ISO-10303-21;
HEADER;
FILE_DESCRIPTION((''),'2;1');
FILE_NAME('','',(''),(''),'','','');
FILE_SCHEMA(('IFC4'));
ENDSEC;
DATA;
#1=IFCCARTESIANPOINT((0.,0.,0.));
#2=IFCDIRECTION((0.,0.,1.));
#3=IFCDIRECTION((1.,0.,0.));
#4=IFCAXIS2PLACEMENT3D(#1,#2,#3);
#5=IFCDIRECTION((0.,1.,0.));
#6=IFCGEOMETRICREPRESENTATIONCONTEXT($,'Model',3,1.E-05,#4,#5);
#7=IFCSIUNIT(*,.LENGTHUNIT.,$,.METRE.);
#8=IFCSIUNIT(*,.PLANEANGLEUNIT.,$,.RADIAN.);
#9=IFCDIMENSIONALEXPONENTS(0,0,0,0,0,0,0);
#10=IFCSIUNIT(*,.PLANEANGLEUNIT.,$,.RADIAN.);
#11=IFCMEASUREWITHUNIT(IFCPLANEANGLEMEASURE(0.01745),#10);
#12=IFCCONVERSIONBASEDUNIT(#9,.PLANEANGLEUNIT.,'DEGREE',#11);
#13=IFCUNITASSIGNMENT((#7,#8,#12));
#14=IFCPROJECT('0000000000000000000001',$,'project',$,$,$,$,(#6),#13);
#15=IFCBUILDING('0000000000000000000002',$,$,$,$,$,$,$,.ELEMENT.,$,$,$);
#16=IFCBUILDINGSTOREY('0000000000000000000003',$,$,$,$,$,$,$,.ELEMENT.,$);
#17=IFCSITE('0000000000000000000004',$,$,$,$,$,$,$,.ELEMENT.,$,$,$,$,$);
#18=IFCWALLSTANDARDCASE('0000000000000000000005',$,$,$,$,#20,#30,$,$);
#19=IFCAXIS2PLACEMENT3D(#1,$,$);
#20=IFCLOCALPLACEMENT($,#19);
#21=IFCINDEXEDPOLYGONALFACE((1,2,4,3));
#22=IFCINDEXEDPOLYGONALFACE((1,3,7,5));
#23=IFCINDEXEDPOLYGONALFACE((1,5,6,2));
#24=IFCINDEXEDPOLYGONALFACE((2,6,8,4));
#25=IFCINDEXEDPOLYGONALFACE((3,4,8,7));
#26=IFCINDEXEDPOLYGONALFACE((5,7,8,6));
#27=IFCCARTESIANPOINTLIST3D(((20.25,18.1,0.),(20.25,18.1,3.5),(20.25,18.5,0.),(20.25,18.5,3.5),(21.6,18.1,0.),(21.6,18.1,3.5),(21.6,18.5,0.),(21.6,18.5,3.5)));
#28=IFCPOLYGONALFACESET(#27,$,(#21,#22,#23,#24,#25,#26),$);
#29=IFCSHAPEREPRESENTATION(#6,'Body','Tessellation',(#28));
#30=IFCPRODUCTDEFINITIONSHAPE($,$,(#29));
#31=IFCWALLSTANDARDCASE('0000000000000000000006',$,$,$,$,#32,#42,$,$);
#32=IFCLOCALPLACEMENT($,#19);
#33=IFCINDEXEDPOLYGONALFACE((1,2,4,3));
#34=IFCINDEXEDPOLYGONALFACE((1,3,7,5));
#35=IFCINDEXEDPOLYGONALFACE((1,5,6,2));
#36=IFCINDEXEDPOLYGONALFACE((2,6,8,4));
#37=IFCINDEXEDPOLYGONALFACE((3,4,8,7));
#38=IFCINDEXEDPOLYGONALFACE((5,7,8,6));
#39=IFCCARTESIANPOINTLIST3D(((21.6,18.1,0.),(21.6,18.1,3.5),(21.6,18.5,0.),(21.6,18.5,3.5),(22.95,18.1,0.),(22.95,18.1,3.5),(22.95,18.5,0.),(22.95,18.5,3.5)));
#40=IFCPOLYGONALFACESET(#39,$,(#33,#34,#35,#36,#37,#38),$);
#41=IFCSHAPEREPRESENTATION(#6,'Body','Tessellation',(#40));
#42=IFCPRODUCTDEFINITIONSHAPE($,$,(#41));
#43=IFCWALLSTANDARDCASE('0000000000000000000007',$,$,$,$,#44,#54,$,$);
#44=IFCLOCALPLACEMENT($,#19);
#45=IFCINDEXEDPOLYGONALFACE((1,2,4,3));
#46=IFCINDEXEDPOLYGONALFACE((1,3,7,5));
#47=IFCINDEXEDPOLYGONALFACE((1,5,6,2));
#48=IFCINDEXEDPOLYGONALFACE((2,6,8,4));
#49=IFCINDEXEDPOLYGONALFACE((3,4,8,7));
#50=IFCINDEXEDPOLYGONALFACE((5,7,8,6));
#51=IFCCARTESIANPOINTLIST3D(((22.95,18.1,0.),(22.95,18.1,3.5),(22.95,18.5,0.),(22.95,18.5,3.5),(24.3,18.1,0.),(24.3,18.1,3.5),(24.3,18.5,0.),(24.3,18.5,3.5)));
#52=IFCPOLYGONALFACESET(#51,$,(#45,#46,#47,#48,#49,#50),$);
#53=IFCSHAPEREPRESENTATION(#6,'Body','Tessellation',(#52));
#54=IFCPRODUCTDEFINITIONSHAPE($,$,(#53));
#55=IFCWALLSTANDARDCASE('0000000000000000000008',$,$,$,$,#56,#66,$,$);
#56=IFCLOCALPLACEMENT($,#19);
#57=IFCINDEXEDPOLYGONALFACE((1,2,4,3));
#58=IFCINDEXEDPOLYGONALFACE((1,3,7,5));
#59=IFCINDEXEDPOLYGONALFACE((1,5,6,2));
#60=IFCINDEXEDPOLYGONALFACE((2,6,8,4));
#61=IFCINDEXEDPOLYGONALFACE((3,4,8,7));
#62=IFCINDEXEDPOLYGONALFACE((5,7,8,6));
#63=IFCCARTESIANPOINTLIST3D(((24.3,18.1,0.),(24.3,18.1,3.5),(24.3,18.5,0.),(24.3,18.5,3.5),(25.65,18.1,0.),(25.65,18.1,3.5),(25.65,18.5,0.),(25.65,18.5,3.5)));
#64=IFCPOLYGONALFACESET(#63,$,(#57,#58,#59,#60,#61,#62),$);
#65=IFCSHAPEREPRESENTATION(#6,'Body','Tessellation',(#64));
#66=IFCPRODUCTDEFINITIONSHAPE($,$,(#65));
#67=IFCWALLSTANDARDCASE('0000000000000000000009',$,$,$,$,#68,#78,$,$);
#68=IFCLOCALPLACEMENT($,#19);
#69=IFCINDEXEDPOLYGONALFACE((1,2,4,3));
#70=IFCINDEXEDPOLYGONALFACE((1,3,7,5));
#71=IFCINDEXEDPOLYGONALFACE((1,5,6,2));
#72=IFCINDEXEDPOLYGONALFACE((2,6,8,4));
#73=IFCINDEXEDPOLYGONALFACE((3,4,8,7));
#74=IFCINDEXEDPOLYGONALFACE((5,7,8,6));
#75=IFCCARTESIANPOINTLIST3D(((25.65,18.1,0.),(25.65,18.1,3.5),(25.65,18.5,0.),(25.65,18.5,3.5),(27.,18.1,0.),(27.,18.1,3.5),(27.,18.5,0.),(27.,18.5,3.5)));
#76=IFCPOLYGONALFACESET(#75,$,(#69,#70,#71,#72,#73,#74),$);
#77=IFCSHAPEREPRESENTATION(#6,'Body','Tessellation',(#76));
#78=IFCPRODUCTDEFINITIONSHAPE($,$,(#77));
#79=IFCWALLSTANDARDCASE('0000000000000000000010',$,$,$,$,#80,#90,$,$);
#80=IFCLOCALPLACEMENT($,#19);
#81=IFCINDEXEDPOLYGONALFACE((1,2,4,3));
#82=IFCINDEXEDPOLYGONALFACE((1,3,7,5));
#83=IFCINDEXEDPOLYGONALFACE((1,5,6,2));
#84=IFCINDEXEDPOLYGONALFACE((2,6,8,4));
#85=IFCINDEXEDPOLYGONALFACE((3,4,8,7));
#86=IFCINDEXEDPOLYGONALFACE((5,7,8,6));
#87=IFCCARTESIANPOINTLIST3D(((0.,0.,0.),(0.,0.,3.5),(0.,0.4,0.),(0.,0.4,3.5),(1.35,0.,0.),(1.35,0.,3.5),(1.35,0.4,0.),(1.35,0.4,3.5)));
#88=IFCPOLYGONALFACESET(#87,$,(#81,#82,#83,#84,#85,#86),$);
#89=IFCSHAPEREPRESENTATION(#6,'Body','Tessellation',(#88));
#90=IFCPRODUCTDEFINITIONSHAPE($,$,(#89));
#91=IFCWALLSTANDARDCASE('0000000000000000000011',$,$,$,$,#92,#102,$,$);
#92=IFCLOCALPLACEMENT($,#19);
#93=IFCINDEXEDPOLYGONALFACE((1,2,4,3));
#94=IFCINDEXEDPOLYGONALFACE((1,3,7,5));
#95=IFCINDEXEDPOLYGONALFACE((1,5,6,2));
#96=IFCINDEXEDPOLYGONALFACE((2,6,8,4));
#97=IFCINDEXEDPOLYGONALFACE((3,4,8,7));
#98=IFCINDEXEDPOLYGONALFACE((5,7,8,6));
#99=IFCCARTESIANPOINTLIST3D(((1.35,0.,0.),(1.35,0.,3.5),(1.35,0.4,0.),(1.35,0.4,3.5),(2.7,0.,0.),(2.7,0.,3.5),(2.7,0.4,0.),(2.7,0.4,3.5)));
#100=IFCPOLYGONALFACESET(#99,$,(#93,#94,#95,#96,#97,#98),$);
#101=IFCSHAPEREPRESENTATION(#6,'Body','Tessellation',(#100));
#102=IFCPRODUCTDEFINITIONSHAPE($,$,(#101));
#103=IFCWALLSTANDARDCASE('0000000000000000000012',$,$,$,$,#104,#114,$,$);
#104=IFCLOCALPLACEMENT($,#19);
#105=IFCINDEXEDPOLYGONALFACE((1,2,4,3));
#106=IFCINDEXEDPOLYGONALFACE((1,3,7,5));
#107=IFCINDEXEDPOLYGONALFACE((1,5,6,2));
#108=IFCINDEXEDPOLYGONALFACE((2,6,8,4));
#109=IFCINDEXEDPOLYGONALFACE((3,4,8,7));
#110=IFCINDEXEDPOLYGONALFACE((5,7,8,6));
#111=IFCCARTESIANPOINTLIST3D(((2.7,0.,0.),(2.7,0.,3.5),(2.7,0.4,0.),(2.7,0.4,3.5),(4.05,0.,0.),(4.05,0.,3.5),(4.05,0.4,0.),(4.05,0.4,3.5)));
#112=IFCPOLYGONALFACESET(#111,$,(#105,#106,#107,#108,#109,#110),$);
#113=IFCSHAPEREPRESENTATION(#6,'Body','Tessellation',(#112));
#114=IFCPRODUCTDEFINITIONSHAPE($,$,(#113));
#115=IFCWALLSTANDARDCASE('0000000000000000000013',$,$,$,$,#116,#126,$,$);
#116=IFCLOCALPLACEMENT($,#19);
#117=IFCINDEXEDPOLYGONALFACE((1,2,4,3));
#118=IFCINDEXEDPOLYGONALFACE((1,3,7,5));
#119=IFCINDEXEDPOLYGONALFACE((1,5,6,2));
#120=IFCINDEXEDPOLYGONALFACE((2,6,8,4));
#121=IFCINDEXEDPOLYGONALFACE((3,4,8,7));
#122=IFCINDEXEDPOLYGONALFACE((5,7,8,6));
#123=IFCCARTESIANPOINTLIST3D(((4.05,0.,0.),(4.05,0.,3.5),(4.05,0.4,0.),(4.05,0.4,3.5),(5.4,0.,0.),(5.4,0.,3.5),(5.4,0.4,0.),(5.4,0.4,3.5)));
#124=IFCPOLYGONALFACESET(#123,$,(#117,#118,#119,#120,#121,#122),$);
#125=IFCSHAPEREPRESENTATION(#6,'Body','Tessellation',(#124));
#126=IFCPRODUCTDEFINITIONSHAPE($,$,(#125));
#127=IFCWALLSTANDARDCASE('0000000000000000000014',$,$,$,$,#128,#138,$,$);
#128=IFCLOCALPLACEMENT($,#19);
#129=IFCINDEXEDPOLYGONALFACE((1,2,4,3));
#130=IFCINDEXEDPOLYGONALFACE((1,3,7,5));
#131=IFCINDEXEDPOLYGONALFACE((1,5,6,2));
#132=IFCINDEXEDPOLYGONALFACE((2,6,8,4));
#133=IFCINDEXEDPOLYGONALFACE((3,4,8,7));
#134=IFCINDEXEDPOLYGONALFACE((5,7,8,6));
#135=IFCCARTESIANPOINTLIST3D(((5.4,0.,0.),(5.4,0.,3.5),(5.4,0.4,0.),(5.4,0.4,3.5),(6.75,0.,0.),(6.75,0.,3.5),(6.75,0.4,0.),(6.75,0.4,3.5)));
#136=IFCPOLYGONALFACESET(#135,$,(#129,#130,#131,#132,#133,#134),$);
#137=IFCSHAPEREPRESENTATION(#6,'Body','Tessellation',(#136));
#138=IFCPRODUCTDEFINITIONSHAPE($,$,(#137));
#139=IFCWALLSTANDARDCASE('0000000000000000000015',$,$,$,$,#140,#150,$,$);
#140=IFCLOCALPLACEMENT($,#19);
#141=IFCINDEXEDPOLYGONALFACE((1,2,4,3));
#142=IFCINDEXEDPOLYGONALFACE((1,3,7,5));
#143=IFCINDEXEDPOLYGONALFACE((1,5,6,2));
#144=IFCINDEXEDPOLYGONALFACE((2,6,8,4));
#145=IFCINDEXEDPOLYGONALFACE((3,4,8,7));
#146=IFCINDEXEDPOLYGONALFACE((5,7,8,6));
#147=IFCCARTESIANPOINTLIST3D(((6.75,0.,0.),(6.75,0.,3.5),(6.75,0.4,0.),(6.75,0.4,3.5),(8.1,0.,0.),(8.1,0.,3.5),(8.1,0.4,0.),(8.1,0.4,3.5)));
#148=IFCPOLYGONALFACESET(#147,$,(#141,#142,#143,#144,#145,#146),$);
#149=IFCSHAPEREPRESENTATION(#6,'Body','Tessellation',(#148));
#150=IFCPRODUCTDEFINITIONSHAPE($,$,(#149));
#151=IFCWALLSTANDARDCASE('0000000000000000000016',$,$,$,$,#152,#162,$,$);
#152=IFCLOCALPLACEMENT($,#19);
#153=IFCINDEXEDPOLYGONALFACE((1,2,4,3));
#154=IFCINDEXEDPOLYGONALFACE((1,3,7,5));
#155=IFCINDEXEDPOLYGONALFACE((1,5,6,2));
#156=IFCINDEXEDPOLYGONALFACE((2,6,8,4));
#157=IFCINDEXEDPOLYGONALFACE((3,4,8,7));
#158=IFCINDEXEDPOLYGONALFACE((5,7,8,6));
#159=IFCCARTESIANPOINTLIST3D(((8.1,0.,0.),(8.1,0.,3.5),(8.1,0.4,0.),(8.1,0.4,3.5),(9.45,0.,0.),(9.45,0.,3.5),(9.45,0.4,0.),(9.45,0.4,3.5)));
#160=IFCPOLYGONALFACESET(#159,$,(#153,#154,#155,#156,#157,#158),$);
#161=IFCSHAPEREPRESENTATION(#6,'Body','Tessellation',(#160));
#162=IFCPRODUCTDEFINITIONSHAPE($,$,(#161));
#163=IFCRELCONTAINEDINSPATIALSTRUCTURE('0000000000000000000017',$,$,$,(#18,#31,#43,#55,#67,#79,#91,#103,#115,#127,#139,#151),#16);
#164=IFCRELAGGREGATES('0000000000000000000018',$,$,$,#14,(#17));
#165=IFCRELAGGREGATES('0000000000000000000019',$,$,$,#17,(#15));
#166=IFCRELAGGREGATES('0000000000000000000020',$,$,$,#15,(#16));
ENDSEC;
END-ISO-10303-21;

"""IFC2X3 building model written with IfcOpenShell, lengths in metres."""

from ifc_helpers import new_model, entity, si_unit, converted_unit, direction, origin_with_axes, place, context, project, spatial, polyline, outline, extrude, element, save


model = new_model("IFC2X3")

# Units and contexts
model_context = context("Model", 3, precision=1e-05, world=origin_with_axes(), true_north=direction((0.0, 1.0, 0.0)))
ifc_project = project(units=[si_unit("LENGTHUNIT", "METRE"), si_unit("PLANEANGLEUNIT", "RADIAN"), converted_unit("PLANEANGLEUNIT", "DEGREE", entity("IfcPlaneAngleMeasure", 0.01745), si_unit("PLANEANGLEUNIT", "RADIAN"), dimensions=[0, 0, 0, 0, 0, 0, 0])], contexts=[model_context])

# Site, building, storey
site = spatial("IfcSite", under=ifc_project, CompositionType="ELEMENT")
building = spatial("IfcBuilding", under=site, CompositionType="ELEMENT")
storey = spatial("IfcBuildingStorey", under=building, CompositionType="ELEMENT")

# Walls
wall_1_placement = place(None, origin_with_axes())
element("IfcWallStandardCase", 1, at=wall_1_placement, inside=storey, context=model_context, shape_type="SweptSolid", body=[
    extrude(outline(polyline([(20.25, 18.1, 0.0), (21.6, 18.1, 0.0), (21.6, 18.5, 0.0), (20.25, 18.5, 0.0)])), origin_with_axes(), (0.0, 0.0, 1.0), 3.5),
])
wall_2_placement = place(None, origin_with_axes())
element("IfcWallStandardCase", 2, at=wall_2_placement, inside=storey, context=model_context, shape_type="SweptSolid", body=[
    extrude(outline(polyline([(21.6, 18.1, 0.0), (22.95, 18.1, 0.0), (22.95, 18.5, 0.0), (21.6, 18.5, 0.0)])), origin_with_axes(), (0.0, 0.0, 1.0), 3.5),
])
wall_3_placement = place(None, origin_with_axes())
element("IfcWallStandardCase", 3, at=wall_3_placement, inside=storey, context=model_context, shape_type="SweptSolid", body=[
    extrude(outline(polyline([(22.95, 18.1, 0.0), (24.3, 18.1, 0.0), (24.3, 18.5, 0.0), (22.95, 18.5, 0.0)])), origin_with_axes(), (0.0, 0.0, 1.0), 3.5),
])
wall_4_placement = place(None, origin_with_axes())
element("IfcWallStandardCase", 4, at=wall_4_placement, inside=storey, context=model_context, shape_type="SweptSolid", body=[
    extrude(outline(polyline([(24.3, 18.1, 0.0), (25.65, 18.1, 0.0), (25.65, 18.5, 0.0), (24.3, 18.5, 0.0)])), origin_with_axes(), (0.0, 0.0, 1.0), 3.5),
])
wall_5_placement = place(None, origin_with_axes())
element("IfcWallStandardCase", 5, at=wall_5_placement, inside=storey, context=model_context, shape_type="SweptSolid", body=[
    extrude(outline(polyline([(25.65, 18.1, 0.0), (27.0, 18.1, 0.0), (27.0, 18.5, 0.0), (25.65, 18.5, 0.0)])), origin_with_axes(), (0.0, 0.0, 1.0), 3.5),
])
wall_6_placement = place(None, origin_with_axes())
element("IfcWallStandardCase", 6, at=wall_6_placement, inside=storey, context=model_context, shape_type="SweptSolid", body=[
    extrude(outline(polyline([(0.0, 0.0, 0.0), (1.35, 0.0, 0.0), (1.35, 0.4, 0.0), (0.0, 0.4, 0.0)])), origin_with_axes(), (0.0, 0.0, 1.0), 3.5),
])
wall_7_placement = place(None, origin_with_axes())
element("IfcWallStandardCase", 7, at=wall_7_placement, inside=storey, context=model_context, shape_type="SweptSolid", body=[
    extrude(outline(polyline([(1.35, 0.0, 0.0), (2.7, 0.0, 0.0), (2.7, 0.4, 0.0), (1.35, 0.4, 0.0)])), origin_with_axes(), (0.0, 0.0, 1.0), 3.5),
])
wall_8_placement = place(None, origin_with_axes())
element("IfcWallStandardCase", 8, at=wall_8_placement, inside=storey, context=model_context, shape_type="SweptSolid", body=[
    extrude(outline(polyline([(2.7, 0.0, 0.0), (4.05, 0.0, 0.0), (4.05, 0.4, 0.0), (2.7, 0.4, 0.0)])), origin_with_axes(), (0.0, 0.0, 1.0), 3.5),
])
wall_9_placement = place(None, origin_with_axes())
element("IfcWallStandardCase", 9, at=wall_9_placement, inside=storey, context=model_context, shape_type="SweptSolid", body=[
    extrude(outline(polyline([(4.05, 0.0, 0.0), (5.4, 0.0, 0.0), (5.4, 0.4, 0.0), (4.05, 0.4, 0.0)])), origin_with_axes(), (0.0, 0.0, 1.0), 3.5),
])
wall_10_placement = place(None, origin_with_axes())
element("IfcWallStandardCase", 10, at=wall_10_placement, inside=storey, context=model_context, shape_type="SweptSolid", body=[
    extrude(outline(polyline([(5.4, 0.0, 0.0), (6.75, 0.0, 0.0), (6.75, 0.4, 0.0), (5.4, 0.4, 0.0)])), origin_with_axes(), (0.0, 0.0, 1.0), 3.5),
])
wall_11_placement = place(None, origin_with_axes())
element("IfcWallStandardCase", 11, at=wall_11_placement, inside=storey, context=model_context, shape_type="SweptSolid", body=[
    extrude(outline(polyline([(6.75, 0.0, 0.0), (8.1, 0.0, 0.0), (8.1, 0.4, 0.0), (6.75, 0.4, 0.0)])), origin_with_axes(), (0.0, 0.0, 1.0), 3.5),
])
wall_12_placement = place(None, origin_with_axes())
element("IfcWallStandardCase", 12, at=wall_12_placement, inside=storey, context=model_context, shape_type="SweptSolid", body=[
    extrude(outline(polyline([(8.1, 0.0, 0.0), (9.45, 0.0, 0.0), (9.45, 0.4, 0.0), (8.1, 0.4, 0.0)])), origin_with_axes(), (0.0, 0.0, 1.0), 3.5),
])

save(model, "model.ifc")
